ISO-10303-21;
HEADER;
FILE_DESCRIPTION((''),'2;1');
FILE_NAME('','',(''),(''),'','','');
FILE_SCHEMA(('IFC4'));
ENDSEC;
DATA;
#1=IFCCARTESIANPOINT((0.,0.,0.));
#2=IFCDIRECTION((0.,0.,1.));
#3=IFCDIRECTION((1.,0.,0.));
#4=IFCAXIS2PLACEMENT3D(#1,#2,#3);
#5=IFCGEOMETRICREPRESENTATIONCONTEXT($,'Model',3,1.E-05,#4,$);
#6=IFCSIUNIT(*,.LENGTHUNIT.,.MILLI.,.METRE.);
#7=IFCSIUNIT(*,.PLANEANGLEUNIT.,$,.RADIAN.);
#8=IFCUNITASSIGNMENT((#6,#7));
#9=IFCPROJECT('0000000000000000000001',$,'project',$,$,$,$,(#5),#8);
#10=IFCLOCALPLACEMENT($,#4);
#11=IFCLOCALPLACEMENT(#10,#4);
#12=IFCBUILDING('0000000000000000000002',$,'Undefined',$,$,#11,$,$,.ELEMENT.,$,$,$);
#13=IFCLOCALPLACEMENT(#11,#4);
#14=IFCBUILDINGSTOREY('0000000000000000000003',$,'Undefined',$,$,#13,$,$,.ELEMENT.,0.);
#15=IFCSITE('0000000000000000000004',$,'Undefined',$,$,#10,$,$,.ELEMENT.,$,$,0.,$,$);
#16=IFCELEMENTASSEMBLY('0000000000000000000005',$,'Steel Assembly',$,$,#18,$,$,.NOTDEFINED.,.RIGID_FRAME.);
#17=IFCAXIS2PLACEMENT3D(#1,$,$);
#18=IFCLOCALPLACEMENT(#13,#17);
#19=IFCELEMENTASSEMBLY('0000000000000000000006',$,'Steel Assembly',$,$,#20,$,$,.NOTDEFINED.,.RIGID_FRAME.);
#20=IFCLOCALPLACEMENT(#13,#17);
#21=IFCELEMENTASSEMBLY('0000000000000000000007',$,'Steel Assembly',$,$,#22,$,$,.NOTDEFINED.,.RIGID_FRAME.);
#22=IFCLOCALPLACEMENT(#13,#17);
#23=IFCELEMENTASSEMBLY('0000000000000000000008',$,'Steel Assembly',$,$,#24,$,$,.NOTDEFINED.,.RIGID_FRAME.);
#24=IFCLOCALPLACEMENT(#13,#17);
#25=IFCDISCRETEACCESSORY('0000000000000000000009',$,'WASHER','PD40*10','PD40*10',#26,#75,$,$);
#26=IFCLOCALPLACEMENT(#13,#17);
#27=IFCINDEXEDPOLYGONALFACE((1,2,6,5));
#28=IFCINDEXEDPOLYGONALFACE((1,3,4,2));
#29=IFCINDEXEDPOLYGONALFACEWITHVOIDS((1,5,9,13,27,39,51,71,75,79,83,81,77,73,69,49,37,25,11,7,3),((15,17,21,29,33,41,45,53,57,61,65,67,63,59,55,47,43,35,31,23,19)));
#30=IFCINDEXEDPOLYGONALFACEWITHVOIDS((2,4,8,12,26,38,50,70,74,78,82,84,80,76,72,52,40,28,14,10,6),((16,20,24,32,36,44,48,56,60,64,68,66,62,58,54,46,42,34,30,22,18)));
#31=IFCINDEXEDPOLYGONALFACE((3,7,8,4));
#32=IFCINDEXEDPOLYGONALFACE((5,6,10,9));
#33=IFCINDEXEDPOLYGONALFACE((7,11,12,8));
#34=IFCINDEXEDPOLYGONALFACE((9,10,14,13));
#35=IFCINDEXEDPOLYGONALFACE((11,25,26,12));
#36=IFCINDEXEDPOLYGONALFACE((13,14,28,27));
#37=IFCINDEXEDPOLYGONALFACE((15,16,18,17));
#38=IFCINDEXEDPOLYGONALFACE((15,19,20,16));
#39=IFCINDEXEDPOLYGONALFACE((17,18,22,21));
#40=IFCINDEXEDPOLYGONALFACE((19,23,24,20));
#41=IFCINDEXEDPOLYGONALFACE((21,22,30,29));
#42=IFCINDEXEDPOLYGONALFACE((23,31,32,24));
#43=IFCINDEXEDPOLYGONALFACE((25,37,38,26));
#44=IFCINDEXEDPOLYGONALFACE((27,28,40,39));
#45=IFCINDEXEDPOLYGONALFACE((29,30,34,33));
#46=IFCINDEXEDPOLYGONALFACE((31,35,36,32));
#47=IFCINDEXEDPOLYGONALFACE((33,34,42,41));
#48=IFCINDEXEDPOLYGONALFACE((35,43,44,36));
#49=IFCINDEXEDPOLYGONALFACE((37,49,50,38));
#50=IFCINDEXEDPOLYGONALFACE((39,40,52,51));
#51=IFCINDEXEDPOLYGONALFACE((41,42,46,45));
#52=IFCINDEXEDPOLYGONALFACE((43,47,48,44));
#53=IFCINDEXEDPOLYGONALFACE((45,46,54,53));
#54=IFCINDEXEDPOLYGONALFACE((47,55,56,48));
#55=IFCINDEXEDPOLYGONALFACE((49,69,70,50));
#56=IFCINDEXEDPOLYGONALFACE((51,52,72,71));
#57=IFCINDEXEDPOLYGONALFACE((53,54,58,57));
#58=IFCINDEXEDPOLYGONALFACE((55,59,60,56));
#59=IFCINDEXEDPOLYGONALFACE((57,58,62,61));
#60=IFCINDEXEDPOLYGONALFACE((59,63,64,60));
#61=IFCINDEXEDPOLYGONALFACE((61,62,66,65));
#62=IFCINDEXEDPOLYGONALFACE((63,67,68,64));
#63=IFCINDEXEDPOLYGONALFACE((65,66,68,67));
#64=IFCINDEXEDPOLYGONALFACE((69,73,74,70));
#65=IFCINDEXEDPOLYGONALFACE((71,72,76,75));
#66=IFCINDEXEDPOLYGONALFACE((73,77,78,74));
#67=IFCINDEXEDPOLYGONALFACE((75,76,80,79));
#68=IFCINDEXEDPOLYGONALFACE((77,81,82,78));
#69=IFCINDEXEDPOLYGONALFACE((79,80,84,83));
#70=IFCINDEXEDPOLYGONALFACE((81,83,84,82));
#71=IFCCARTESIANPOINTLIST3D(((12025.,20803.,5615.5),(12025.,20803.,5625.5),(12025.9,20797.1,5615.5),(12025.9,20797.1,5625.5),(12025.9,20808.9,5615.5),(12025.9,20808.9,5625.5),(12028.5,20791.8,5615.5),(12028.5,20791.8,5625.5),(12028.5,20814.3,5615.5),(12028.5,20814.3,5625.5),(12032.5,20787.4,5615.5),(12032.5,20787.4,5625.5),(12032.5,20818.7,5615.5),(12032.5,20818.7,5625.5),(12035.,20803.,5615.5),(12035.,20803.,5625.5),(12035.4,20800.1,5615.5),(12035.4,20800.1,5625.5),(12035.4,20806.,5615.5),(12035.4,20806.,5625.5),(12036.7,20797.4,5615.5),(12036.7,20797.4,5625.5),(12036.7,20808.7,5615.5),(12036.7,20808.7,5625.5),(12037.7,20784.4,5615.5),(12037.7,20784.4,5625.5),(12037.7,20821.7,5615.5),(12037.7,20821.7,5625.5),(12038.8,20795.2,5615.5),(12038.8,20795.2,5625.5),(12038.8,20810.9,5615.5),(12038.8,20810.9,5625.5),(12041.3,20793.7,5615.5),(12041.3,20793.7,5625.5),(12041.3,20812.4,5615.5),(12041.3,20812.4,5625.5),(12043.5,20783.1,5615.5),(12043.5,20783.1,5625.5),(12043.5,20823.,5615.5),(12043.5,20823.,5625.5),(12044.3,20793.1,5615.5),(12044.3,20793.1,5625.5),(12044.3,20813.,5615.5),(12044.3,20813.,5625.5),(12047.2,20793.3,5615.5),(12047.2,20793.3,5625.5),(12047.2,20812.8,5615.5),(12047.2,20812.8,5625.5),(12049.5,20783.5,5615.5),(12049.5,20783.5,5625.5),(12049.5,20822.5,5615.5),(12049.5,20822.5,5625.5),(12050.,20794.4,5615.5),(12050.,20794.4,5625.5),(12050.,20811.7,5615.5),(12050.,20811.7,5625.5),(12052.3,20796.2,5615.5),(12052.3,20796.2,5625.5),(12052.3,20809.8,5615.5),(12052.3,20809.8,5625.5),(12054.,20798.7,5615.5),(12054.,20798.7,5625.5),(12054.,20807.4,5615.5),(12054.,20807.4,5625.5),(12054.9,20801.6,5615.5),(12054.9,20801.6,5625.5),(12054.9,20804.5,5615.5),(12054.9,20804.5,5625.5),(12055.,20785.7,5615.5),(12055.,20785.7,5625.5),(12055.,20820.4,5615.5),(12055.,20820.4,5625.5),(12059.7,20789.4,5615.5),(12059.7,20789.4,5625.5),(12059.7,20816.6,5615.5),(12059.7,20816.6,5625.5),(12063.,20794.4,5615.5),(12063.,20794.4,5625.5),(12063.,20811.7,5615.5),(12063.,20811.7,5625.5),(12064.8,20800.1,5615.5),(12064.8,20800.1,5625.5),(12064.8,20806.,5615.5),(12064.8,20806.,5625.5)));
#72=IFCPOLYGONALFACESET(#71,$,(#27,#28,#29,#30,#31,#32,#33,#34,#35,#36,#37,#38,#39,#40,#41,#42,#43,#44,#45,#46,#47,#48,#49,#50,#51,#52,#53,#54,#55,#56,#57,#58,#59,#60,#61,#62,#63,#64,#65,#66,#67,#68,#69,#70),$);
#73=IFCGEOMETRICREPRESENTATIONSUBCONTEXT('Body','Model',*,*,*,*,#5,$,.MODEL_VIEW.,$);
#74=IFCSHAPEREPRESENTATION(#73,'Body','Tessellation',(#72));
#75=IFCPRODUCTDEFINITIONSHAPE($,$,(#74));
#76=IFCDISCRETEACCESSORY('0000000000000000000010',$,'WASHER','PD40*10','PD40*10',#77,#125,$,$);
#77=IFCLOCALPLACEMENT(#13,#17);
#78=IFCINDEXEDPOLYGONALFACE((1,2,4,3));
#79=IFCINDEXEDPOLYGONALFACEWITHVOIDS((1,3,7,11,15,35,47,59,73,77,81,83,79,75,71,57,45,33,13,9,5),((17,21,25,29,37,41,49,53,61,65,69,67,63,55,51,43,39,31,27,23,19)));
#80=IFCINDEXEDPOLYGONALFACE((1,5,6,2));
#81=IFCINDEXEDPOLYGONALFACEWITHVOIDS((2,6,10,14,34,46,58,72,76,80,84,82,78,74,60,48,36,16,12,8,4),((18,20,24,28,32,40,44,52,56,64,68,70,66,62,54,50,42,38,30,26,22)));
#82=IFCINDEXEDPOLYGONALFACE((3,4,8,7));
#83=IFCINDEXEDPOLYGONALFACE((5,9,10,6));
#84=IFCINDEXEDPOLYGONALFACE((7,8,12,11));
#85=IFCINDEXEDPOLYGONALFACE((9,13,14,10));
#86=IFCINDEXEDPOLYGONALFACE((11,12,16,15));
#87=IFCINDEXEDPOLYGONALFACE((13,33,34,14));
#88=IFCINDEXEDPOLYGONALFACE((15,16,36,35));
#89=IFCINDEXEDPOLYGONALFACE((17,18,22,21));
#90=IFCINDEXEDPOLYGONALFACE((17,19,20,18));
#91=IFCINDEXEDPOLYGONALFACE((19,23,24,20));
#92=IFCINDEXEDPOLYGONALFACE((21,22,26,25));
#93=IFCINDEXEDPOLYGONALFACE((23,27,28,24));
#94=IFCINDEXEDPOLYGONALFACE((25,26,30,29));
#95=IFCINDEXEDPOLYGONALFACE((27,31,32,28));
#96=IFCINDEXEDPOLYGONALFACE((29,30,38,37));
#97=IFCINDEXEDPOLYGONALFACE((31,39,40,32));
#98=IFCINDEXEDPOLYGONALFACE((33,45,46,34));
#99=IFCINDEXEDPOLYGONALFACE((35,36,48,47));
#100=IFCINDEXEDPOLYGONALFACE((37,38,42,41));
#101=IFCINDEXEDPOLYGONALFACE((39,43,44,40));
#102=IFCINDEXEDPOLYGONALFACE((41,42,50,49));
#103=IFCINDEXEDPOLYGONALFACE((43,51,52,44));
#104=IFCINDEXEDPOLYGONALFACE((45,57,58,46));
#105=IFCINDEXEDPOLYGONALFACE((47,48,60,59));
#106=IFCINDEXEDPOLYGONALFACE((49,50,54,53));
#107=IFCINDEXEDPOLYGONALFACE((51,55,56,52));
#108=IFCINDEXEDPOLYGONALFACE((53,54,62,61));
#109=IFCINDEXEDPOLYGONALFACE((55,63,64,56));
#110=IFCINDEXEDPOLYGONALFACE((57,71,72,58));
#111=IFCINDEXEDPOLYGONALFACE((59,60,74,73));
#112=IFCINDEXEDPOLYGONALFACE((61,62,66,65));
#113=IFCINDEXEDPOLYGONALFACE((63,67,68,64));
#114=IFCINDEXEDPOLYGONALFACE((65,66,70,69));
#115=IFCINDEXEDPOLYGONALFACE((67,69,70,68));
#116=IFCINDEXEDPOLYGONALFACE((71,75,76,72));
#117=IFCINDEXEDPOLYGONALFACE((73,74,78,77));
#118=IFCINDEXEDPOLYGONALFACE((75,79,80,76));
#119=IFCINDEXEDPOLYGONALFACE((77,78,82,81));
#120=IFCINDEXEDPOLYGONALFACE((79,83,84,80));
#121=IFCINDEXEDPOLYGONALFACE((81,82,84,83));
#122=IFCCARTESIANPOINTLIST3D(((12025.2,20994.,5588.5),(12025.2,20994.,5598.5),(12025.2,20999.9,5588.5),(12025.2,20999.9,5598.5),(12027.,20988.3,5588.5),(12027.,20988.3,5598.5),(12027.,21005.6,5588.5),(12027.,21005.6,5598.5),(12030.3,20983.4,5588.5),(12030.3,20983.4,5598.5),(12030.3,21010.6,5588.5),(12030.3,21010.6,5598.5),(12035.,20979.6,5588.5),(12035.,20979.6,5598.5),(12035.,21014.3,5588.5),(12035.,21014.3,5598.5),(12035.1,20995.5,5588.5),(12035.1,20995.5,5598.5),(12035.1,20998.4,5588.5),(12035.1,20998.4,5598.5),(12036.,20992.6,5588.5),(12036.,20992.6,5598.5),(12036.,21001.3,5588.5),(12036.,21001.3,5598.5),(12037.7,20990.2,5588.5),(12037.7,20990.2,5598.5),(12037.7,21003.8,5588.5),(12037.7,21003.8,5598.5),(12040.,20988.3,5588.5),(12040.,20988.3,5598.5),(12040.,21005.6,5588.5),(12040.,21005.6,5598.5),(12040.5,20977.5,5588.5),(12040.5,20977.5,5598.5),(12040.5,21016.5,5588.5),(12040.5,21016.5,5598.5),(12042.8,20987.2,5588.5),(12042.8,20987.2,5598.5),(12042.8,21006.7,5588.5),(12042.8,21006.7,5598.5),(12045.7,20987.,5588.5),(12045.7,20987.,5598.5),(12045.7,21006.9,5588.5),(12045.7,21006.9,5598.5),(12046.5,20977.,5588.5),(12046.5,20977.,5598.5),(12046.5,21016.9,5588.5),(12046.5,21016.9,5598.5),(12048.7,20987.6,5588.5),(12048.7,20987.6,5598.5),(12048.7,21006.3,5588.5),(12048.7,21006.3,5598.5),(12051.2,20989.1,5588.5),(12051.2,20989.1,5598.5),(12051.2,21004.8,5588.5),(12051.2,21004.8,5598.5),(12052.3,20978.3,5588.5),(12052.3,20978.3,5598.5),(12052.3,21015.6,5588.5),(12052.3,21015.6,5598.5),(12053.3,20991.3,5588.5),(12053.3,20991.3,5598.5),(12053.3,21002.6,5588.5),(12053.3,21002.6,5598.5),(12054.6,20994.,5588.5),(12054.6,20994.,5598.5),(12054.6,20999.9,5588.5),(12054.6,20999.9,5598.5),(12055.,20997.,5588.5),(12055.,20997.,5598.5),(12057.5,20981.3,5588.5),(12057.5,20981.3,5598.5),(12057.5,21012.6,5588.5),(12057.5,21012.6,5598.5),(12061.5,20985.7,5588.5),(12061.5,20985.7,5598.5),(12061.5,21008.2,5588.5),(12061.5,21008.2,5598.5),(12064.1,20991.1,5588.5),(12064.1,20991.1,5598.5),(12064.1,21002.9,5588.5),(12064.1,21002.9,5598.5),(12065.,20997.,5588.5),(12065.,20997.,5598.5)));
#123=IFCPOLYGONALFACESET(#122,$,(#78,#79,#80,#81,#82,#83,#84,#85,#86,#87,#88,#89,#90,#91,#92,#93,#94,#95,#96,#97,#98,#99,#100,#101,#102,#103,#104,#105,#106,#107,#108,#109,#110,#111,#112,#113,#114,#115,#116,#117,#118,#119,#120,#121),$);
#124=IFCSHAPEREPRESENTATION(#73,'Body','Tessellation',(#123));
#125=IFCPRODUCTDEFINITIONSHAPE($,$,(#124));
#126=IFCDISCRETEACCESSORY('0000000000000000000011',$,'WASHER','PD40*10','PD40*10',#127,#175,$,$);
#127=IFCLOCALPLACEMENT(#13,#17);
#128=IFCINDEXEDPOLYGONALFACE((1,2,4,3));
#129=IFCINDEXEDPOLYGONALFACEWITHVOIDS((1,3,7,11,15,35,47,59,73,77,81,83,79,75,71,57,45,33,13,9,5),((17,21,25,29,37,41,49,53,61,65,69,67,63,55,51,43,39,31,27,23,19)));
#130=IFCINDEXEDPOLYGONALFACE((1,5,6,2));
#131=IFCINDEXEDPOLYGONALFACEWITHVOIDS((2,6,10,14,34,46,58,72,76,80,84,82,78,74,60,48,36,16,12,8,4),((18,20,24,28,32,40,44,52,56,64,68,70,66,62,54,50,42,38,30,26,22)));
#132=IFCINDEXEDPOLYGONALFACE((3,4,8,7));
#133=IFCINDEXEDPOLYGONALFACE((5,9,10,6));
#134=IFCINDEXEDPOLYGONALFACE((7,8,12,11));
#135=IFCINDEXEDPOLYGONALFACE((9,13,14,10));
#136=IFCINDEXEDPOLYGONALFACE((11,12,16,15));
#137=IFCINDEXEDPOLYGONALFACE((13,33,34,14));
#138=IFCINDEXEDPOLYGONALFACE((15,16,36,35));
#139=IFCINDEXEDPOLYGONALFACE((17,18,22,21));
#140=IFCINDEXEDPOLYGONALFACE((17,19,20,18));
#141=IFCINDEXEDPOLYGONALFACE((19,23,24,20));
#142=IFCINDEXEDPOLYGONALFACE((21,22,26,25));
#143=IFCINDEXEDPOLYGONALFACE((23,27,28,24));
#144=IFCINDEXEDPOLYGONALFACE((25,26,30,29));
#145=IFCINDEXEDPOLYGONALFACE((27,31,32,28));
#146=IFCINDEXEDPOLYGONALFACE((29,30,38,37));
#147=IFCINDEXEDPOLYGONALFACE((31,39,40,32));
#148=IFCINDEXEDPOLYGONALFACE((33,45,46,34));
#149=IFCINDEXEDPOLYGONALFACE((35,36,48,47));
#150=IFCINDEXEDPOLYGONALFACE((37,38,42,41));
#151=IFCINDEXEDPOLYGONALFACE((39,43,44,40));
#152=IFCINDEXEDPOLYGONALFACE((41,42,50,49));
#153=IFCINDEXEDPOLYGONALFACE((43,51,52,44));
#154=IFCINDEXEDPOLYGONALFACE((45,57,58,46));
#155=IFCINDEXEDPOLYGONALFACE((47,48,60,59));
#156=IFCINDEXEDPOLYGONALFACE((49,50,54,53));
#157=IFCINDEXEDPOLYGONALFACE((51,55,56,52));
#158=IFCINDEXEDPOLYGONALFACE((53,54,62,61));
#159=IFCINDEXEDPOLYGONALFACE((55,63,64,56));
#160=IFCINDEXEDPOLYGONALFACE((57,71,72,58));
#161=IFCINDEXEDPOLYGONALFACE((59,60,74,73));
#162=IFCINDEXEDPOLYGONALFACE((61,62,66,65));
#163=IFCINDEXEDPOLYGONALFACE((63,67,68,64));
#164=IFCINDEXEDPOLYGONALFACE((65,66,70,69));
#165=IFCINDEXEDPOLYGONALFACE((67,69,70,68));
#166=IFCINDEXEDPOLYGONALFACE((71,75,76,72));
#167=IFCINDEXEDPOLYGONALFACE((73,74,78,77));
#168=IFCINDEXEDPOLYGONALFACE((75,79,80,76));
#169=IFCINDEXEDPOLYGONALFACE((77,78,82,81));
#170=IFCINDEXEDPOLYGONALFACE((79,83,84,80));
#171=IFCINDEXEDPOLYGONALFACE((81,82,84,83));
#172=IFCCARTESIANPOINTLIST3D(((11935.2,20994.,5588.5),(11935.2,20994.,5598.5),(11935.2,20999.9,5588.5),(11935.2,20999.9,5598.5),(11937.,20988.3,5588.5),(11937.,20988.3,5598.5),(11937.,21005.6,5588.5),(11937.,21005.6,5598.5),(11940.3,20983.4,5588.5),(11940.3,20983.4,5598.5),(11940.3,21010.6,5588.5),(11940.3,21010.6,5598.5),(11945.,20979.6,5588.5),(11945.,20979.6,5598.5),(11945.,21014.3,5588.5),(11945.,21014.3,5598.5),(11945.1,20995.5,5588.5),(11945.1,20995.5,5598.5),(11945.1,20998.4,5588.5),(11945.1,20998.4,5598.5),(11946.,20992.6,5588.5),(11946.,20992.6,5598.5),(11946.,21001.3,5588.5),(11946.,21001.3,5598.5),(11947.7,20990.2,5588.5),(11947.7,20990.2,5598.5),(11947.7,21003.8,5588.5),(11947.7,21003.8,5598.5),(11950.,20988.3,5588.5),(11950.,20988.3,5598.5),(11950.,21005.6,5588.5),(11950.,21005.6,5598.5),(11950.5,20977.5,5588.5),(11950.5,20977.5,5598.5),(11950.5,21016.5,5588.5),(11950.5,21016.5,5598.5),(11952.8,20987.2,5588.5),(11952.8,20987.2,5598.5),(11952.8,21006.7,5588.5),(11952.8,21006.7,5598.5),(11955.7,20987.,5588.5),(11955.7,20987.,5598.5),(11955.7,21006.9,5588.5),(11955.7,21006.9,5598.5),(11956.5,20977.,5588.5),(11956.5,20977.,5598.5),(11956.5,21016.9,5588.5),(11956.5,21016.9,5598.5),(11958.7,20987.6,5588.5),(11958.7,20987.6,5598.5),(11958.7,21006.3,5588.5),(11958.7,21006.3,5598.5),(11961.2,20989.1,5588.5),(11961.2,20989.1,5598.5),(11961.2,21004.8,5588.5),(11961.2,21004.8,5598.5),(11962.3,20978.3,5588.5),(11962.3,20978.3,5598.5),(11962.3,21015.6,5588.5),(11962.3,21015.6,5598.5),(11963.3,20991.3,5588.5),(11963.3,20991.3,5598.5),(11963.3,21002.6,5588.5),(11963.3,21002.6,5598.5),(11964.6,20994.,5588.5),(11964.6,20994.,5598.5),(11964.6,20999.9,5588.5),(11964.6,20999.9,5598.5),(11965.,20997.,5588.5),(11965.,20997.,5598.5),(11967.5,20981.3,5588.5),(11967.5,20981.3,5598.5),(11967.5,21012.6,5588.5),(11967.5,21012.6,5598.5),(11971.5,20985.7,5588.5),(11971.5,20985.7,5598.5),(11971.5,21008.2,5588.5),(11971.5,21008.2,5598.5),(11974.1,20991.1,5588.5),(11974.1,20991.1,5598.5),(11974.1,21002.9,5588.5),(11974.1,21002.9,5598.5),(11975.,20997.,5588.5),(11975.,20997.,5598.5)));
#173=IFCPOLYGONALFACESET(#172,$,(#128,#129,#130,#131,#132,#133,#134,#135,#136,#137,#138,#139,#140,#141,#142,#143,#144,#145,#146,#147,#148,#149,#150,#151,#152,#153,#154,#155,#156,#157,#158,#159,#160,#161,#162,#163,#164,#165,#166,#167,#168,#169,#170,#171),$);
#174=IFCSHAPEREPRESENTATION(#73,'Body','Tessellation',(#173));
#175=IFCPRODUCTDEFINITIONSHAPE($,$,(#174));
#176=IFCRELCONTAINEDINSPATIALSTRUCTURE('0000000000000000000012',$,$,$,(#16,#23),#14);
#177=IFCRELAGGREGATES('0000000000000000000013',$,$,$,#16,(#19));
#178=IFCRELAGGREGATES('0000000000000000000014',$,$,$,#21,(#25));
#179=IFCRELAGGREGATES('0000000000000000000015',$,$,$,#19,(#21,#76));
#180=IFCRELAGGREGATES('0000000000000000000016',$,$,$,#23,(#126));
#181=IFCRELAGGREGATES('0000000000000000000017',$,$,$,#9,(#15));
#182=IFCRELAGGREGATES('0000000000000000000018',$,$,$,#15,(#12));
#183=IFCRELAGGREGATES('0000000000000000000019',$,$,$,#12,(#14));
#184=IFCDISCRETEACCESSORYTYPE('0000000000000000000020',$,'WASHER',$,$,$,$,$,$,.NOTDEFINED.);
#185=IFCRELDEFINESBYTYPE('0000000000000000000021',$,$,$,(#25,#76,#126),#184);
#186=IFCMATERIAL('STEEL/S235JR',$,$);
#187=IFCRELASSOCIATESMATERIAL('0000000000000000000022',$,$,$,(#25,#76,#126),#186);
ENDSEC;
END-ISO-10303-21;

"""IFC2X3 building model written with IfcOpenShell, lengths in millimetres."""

from ifc_helpers import new_model, si_unit, frame, origin_with_axes, origin_2d_with_axis, place, context, subcontext, project, spatial, hollow_circle, extrude, material, type_object, element, aggregate, save


model = new_model("IFC2X3")

# Units and contexts
model_context = context("Model", 3, precision=1e-05, world=origin_with_axes())
body_context = subcontext(model_context, "Body", "Model", "MODEL_VIEW")
ifc_project = project(units=[si_unit("LENGTHUNIT", "METRE", prefix="MILLI"), si_unit("PLANEANGLEUNIT", "RADIAN")], contexts=[model_context])

# Site, building, storey
site_placement = place(None, origin_with_axes())
site = spatial("IfcSite", under=ifc_project, at=site_placement, Name="Undefined", CompositionType="ELEMENT", RefElevation=0.0)
building_placement = place(site_placement, origin_with_axes())
building = spatial("IfcBuilding", under=site, at=building_placement, Name="Undefined", CompositionType="ELEMENT")
storey_placement = place(building_placement, origin_with_axes())
storey = spatial("IfcBuildingStorey", under=building, at=storey_placement, Name="Undefined", CompositionType="ELEMENT", Elevation=0.0)

# Shared definitions
ifc_material_1 = material(Name="STEEL/S235JR")

# Element assemblies
assembly_1_placement = place(storey_placement, origin_with_axes())
assembly_1 = element("IfcElementAssembly", 1, at=assembly_1_placement, inside=storey, Name="Steel Assembly", AssemblyPlace="NOTDEFINED", PredefinedType="RIGID_FRAME")
assembly_2_placement = place(assembly_1_placement, origin_with_axes())
assembly_2 = element("IfcElementAssembly", 2, at=assembly_2_placement, Name="Steel Assembly", AssemblyPlace="NOTDEFINED", PredefinedType="RIGID_FRAME")
aggregate(assembly_1, [assembly_2])
assembly_3_placement = place(assembly_2_placement, origin_with_axes())
assembly_3 = element("IfcElementAssembly", 3, at=assembly_3_placement, Name="Steel Assembly", AssemblyPlace="NOTDEFINED", PredefinedType="RIGID_FRAME")

# Element assembly
assembly_4_placement = place(storey_placement, origin_with_axes())
assembly_4 = element("IfcElementAssembly", 4, at=assembly_4_placement, inside=storey, Name="Steel Assembly", AssemblyPlace="NOTDEFINED", PredefinedType="RIGID_FRAME")

# Discrete accessories
discrete_accessory_type_1 = type_object("IfcDiscreteAccessoryType", Name="WASHER")
discrete_accessory_1_placement = place(assembly_3_placement, frame((12045.0, 20803.0, 5625.5), z_axis=(0.0, -1.0, 0.0), x_axis=(0.0, 0.0, -1.0)))
discrete_accessory_1 = element("IfcDiscreteAccessory", 5, at=discrete_accessory_1_placement, type_object=discrete_accessory_type_1, material=ifc_material_1, Name="WASHER", Description="PD40*10", ObjectType="PD40*10", context=body_context, shape_type="SweptSolid", body=[
    extrude(hollow_circle(Radius=20.0, WallThickness=10.0, at=origin_2d_with_axis()), frame((10.0, 0.0, 0.0), z_axis=(-1.0, 0.0, 0.0), x_axis=(0.0, -1.0, 0.0)), (0.0, 0.0, 1.0), 10.0),
])
aggregate(assembly_3, [discrete_accessory_1])
discrete_accessory_2_placement = place(assembly_2_placement, frame((12045.0, 20997.0, 5598.5), z_axis=(0.0, 1.0, 0.0), x_axis=(0.0, 0.0, -1.0)))
discrete_accessory_2 = element("IfcDiscreteAccessory", 6, at=discrete_accessory_2_placement, type_object=discrete_accessory_type_1, material=ifc_material_1, Name="WASHER", Description="PD40*10", ObjectType="PD40*10", context=body_context, shape_type="SweptSolid", body=[
    extrude(hollow_circle(Radius=20.0, WallThickness=10.0, at=origin_2d_with_axis()), frame((10.0, 0.0, 0.0), z_axis=(-1.0, 0.0, 0.0), x_axis=(0.0, -1.0, 0.0)), (0.0, 0.0, 1.0), 10.0),
])
aggregate(assembly_2, [assembly_3, discrete_accessory_2])
discrete_accessory_3_placement = place(assembly_4_placement, frame((11955.0, 20997.0, 5598.5), z_axis=(0.0, 1.0, 0.0), x_axis=(0.0, 0.0, -1.0)))
discrete_accessory_3 = element("IfcDiscreteAccessory", 7, at=discrete_accessory_3_placement, type_object=discrete_accessory_type_1, material=ifc_material_1, Name="WASHER", Description="PD40*10", ObjectType="PD40*10", context=body_context, shape_type="SweptSolid", body=[
    extrude(hollow_circle(Radius=20.0, WallThickness=10.0, at=origin_2d_with_axis()), frame((10.0, 0.0, 0.0), z_axis=(-1.0, 0.0, 0.0), x_axis=(0.0, -1.0, 0.0)), (0.0, 0.0, 1.0), 10.0),
])
aggregate(assembly_4, [discrete_accessory_3])

save(model, "model.ifc")
